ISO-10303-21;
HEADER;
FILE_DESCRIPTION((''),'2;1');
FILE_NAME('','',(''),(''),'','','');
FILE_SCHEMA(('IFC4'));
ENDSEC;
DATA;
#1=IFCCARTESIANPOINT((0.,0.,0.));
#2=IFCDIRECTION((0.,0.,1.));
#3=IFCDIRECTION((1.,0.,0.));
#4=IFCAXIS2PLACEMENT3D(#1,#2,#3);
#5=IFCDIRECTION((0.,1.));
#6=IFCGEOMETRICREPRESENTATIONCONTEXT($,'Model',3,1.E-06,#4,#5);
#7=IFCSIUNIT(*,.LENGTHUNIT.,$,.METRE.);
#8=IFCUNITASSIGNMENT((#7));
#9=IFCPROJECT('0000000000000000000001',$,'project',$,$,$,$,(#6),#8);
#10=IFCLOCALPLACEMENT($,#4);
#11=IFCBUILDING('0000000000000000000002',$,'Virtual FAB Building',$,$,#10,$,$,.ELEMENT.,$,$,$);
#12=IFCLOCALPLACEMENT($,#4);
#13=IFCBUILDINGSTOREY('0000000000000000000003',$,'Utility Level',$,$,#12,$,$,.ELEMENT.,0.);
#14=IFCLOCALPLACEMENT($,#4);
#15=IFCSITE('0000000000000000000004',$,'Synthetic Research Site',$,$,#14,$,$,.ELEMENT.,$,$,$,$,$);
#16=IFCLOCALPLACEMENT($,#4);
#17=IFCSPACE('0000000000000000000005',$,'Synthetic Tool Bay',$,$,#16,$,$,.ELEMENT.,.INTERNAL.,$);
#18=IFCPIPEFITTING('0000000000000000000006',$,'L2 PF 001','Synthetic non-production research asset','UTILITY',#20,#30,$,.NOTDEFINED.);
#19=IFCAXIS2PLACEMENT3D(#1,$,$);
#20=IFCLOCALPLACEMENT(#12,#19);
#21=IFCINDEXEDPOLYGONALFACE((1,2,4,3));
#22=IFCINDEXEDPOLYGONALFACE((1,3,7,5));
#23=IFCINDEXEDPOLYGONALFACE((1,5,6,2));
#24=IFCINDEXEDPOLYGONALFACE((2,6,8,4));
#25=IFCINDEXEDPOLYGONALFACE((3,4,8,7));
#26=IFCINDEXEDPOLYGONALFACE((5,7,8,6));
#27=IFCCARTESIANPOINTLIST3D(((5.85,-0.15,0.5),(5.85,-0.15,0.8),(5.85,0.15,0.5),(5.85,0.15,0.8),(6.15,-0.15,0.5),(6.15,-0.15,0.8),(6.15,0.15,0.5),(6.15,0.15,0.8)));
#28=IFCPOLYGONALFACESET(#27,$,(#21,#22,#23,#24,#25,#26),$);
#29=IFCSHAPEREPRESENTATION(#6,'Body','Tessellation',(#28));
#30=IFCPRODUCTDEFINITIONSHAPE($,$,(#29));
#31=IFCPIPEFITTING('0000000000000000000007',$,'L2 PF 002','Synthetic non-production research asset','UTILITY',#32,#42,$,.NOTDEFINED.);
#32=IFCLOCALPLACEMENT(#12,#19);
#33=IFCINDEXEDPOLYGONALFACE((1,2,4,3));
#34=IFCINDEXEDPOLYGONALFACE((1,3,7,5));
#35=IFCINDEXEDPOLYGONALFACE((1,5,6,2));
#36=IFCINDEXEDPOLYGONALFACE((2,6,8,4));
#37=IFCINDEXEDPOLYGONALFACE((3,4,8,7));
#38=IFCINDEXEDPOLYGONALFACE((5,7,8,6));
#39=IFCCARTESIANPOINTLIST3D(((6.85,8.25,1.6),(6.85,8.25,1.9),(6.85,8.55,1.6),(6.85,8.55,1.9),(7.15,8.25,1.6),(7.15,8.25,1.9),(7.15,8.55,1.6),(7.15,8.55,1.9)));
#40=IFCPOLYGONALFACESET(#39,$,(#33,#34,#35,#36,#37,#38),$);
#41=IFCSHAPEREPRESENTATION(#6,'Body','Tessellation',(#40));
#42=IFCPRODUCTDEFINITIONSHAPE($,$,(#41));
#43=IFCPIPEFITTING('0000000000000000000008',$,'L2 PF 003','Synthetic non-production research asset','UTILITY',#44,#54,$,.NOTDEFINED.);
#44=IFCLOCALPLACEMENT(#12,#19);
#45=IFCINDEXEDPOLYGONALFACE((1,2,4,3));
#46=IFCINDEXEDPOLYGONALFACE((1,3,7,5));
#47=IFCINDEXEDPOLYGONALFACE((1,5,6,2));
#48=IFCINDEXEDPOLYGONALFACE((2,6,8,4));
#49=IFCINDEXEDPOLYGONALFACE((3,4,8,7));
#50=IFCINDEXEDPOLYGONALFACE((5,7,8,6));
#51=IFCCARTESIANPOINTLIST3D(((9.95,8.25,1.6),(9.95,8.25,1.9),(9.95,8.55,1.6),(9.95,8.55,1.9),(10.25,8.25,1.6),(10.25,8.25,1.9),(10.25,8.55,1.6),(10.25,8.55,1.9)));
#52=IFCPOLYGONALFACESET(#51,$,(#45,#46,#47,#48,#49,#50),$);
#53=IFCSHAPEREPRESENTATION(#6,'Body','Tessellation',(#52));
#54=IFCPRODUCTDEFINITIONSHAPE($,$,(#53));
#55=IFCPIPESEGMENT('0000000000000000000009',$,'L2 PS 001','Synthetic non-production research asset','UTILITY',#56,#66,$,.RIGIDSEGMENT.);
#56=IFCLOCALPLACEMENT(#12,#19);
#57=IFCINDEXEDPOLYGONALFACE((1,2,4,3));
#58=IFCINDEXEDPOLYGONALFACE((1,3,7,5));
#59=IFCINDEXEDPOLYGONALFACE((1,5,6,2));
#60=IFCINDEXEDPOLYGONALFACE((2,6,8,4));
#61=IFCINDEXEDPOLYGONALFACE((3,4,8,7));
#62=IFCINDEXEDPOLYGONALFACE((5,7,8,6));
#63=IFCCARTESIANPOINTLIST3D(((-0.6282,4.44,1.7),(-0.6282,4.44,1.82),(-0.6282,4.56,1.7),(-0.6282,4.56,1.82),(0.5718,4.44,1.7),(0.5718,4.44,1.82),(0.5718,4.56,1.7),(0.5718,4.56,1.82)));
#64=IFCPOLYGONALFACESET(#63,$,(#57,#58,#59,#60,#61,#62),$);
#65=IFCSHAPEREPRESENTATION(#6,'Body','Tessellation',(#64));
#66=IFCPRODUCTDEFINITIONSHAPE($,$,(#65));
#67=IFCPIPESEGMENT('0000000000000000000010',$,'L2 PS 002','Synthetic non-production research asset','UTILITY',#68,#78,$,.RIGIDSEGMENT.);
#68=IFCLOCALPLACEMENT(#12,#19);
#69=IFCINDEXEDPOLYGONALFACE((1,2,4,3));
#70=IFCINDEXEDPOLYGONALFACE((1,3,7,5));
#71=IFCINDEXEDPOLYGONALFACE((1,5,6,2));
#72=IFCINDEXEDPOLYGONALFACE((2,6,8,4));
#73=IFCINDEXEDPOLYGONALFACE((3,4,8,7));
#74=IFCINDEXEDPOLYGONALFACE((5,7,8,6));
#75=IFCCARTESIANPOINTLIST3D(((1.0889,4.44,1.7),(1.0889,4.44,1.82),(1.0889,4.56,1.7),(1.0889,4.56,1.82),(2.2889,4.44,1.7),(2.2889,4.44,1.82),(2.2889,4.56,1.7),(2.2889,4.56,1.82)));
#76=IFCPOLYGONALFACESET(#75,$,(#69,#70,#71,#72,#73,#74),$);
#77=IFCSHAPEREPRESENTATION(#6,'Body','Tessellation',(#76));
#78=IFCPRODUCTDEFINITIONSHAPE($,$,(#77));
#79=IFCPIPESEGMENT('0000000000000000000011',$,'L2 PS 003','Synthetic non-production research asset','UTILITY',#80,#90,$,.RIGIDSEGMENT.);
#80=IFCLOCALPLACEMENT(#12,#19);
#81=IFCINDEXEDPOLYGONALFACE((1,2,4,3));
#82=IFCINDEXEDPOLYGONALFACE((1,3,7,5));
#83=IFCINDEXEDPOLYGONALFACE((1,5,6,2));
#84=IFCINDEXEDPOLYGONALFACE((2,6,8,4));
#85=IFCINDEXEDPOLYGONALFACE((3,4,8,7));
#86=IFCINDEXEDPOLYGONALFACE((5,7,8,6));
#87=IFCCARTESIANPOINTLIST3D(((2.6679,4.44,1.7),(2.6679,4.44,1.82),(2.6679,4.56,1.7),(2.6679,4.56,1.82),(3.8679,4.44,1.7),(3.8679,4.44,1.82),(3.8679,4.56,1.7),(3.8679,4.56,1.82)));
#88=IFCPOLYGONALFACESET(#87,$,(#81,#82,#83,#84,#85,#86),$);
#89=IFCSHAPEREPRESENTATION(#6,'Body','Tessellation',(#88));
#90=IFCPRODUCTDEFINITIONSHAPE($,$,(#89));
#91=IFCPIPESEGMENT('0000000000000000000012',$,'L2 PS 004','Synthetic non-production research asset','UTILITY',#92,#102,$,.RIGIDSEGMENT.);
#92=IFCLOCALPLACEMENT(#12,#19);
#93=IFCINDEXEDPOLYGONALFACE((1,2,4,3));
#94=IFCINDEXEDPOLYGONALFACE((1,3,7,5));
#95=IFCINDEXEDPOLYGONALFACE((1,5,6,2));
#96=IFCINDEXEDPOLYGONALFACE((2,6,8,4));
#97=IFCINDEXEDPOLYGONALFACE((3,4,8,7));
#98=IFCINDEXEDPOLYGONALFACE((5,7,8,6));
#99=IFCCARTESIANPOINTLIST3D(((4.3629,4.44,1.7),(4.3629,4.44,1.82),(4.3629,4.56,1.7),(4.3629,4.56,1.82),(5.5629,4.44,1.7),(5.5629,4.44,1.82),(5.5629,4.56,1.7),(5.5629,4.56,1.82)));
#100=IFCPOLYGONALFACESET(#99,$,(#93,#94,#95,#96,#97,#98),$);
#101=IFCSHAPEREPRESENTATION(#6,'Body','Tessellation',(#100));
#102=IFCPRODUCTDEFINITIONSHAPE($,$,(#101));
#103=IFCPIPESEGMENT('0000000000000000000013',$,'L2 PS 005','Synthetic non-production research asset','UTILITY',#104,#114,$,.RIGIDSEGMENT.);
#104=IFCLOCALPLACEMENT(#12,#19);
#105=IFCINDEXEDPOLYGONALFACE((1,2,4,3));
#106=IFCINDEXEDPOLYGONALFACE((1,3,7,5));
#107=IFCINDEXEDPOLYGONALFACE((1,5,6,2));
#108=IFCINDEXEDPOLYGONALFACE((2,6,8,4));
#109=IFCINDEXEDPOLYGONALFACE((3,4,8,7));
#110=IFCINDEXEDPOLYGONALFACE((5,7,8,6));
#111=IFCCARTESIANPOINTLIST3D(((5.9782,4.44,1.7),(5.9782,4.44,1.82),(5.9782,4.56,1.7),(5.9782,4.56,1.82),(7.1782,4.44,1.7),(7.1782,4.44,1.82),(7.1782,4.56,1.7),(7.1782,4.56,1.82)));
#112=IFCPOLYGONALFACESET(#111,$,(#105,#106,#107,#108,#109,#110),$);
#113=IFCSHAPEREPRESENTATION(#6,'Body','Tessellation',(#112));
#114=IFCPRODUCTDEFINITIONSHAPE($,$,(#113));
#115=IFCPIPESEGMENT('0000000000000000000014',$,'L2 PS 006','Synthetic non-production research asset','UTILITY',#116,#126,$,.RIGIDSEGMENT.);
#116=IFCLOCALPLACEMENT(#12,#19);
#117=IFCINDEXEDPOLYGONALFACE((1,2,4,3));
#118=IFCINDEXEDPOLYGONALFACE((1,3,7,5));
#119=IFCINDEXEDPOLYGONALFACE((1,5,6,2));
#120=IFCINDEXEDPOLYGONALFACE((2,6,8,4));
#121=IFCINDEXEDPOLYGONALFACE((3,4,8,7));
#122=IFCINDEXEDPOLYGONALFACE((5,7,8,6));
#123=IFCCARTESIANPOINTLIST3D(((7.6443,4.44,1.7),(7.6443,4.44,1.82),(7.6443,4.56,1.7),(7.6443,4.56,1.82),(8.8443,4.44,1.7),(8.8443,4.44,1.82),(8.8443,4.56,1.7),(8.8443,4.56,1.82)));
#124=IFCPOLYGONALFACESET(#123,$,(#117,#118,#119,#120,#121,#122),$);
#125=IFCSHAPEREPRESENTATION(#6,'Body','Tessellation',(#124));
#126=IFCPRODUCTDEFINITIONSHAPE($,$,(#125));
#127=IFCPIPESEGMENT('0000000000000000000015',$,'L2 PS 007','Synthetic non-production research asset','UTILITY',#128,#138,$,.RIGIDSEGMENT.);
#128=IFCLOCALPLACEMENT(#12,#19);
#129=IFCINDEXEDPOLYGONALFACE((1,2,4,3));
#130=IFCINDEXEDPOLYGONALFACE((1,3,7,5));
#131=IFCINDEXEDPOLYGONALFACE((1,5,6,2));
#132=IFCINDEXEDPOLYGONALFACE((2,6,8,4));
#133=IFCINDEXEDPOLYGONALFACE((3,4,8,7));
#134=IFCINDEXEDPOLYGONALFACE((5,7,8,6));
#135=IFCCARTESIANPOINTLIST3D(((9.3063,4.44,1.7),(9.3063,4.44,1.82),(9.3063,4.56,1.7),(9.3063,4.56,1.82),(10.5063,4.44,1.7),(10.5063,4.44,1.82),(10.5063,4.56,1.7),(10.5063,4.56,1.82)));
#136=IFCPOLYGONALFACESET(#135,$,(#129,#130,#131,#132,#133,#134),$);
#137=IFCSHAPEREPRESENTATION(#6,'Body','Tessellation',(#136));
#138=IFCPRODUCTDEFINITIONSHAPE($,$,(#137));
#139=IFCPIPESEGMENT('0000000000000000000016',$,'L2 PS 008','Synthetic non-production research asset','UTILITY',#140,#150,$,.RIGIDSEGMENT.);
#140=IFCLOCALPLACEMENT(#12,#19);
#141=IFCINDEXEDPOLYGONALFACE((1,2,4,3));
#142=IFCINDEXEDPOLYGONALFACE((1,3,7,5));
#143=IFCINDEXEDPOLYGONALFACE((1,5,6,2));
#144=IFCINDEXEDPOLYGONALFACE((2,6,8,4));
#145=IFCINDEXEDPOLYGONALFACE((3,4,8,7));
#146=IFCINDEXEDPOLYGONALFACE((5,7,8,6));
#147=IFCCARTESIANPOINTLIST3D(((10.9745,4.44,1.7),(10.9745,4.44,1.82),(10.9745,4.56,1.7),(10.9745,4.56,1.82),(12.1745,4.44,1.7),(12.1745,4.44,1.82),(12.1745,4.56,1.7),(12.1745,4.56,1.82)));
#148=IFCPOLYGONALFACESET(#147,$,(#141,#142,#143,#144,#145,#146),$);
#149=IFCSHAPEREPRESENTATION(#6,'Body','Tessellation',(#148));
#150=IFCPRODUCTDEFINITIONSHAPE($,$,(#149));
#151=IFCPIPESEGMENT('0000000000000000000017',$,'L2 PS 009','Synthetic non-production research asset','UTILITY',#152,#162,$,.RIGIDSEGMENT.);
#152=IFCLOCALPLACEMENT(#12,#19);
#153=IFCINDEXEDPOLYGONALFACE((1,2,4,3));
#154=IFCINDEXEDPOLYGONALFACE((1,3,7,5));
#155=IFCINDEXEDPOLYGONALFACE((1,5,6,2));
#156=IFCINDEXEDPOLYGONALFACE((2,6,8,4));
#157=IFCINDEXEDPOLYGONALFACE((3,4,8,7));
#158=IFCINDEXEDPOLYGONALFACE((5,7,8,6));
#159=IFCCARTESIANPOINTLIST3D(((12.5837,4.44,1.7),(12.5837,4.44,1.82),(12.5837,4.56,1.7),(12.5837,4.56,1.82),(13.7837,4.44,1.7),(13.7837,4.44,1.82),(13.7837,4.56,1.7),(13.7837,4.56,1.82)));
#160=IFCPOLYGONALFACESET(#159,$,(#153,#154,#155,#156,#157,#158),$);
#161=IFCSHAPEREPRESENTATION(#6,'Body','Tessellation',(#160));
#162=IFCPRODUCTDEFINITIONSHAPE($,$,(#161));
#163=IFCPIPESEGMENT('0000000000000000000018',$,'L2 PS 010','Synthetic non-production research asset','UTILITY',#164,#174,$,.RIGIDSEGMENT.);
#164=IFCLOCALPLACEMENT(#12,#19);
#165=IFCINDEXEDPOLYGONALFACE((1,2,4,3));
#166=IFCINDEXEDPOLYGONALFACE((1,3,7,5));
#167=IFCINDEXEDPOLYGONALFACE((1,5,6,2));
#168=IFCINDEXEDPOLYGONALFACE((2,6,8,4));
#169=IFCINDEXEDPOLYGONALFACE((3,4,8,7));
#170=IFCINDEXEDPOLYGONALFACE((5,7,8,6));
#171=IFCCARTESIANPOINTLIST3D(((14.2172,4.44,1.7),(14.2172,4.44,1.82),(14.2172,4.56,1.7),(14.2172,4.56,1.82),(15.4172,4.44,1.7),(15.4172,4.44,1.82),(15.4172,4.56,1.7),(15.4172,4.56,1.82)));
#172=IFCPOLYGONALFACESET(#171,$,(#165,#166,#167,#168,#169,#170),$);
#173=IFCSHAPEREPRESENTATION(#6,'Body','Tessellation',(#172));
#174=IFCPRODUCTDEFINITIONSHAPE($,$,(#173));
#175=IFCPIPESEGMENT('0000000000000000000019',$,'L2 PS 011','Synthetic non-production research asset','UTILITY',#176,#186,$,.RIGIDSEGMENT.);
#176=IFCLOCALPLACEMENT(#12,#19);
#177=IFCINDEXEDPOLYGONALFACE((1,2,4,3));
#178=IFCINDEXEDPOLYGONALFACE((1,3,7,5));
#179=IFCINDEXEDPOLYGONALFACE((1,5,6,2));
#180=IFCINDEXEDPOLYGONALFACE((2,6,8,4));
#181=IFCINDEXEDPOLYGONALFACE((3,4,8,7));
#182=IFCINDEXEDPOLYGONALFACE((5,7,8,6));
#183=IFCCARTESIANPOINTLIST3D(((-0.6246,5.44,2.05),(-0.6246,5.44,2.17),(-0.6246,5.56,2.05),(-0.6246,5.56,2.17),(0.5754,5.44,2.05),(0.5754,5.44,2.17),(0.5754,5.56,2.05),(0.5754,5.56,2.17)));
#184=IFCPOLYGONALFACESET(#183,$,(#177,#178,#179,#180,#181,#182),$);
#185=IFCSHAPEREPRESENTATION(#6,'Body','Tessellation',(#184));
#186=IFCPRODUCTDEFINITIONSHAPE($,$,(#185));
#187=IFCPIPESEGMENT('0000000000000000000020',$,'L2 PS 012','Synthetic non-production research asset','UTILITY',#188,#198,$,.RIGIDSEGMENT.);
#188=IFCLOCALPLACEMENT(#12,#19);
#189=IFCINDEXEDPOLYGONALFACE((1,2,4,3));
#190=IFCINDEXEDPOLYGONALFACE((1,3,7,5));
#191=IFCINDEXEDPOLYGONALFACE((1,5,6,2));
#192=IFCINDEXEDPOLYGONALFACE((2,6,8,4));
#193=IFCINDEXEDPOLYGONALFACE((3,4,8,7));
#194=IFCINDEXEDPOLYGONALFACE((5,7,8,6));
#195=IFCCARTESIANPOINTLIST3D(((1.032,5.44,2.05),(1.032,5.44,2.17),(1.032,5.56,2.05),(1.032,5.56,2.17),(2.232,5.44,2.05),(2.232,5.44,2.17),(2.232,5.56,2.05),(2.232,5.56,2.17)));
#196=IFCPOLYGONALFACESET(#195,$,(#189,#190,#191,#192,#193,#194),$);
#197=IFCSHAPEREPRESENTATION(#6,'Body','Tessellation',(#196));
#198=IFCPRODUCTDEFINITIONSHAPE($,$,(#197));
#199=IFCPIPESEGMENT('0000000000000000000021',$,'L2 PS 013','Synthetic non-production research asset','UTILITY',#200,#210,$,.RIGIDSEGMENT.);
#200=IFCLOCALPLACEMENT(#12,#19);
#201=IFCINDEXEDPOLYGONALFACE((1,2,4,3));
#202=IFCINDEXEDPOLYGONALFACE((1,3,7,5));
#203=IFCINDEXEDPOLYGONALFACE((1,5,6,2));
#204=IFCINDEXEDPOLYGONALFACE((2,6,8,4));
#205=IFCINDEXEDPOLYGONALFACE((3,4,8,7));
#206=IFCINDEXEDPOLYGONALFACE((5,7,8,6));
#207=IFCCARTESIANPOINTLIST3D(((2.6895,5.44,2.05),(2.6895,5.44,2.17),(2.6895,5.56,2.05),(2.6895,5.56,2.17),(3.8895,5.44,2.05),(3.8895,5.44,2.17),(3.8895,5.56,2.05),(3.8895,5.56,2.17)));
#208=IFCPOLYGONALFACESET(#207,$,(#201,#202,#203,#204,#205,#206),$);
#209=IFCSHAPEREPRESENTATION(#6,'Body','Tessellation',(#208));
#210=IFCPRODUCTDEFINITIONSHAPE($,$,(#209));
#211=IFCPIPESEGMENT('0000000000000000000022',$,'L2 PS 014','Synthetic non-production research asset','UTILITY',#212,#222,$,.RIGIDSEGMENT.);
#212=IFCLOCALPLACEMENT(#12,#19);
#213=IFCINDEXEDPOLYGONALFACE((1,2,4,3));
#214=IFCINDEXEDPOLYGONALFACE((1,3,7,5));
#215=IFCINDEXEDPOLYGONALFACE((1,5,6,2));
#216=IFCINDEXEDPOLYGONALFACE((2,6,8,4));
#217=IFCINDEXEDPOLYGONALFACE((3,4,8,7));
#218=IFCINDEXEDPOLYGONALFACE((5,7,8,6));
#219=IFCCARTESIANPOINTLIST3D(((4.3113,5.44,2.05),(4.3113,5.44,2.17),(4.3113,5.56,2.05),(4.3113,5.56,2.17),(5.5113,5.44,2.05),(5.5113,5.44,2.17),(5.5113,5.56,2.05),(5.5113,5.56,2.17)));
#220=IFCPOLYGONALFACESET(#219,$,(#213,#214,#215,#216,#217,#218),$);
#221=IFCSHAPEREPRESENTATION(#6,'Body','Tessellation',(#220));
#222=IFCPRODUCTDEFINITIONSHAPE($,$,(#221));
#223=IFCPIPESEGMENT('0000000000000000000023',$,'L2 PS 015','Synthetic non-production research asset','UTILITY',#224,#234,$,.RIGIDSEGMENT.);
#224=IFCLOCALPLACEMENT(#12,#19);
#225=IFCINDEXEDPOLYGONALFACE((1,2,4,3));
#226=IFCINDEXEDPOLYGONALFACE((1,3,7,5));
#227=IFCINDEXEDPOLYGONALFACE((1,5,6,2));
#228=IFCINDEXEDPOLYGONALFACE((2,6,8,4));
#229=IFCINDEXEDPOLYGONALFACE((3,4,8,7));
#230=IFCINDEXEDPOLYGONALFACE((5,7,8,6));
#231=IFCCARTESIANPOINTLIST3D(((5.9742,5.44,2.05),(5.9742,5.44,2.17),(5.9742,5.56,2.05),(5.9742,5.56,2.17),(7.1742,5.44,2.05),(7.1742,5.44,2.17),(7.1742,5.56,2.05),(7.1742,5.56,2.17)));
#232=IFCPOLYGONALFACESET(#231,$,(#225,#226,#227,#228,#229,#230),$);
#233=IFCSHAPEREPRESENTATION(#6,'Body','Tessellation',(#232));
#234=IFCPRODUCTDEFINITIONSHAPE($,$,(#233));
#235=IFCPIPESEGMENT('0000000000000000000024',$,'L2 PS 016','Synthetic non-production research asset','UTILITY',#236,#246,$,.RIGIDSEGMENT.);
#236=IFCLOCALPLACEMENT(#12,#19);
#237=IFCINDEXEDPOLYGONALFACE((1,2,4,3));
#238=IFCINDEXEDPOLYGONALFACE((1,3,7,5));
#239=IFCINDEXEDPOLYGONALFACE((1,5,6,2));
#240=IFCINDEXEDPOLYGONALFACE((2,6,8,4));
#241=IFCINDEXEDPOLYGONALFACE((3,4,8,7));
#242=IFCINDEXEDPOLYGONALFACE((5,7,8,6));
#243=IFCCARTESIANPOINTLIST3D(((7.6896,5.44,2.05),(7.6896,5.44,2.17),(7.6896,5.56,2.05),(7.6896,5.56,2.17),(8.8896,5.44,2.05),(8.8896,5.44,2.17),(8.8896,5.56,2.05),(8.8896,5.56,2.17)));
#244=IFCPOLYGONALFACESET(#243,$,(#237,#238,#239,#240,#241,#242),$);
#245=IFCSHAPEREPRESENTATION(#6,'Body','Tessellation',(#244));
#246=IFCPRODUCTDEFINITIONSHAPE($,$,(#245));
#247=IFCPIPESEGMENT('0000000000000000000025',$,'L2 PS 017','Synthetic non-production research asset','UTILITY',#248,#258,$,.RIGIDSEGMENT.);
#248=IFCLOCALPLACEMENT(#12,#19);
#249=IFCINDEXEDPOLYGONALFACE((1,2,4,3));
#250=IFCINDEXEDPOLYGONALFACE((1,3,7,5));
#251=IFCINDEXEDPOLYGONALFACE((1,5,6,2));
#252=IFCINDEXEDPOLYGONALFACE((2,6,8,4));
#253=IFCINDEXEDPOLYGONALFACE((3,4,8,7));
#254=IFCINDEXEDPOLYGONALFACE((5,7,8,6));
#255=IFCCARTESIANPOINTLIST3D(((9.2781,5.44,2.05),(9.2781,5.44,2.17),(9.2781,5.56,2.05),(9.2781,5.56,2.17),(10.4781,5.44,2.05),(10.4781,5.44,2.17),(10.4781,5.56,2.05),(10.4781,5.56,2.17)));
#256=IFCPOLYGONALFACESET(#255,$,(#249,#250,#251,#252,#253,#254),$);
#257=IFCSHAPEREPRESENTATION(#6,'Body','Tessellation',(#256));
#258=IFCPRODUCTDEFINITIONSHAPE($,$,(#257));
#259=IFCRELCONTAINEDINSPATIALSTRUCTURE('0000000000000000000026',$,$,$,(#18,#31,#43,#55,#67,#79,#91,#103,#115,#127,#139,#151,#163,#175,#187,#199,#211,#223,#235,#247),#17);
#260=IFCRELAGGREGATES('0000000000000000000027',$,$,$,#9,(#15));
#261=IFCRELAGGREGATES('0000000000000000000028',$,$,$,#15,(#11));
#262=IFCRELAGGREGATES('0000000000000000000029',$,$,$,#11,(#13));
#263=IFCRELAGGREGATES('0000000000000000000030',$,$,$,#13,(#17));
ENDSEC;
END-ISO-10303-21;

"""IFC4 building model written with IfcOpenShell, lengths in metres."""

from ifc_helpers import new_model, si_unit, direction, frame, origin_with_axes, origin_2d_with_axis, place, context, project, spatial, rectangle, extrude, element, save


model = new_model("IFC4")

# Units and contexts
model_context = context("Model", 3, precision=1e-06, world=origin_with_axes(), true_north=direction((0.0, 1.0)))
ifc_project = project(units=[si_unit("LENGTHUNIT", "METRE")], contexts=[model_context])

# Site, building, storey, space
site_placement = place(None, origin_with_axes())
site = spatial("IfcSite", under=ifc_project, at=site_placement, Name="Synthetic Research Site", CompositionType="ELEMENT")
building_placement = place(None, origin_with_axes())
building = spatial("IfcBuilding", under=site, at=building_placement, Name="Virtual FAB Building", CompositionType="ELEMENT")
storey_placement = place(None, origin_with_axes())
storey = spatial("IfcBuildingStorey", under=building, at=storey_placement, Name="Utility Level", CompositionType="ELEMENT", Elevation=0.0)
space_placement = place(None, origin_with_axes())
space = spatial("IfcSpace", under=storey, at=space_placement, Name="Synthetic Tool Bay", CompositionType="ELEMENT", PredefinedType="INTERNAL")

# Pipe fittings
for number, where, z_axis, x_axis, name in (
    (1, (6.0, 0.0, 0.5), (0.0, 0.0, 1.0), (1.0, 0.0, 0.0), "L2 PF 001"),
    (2, (7.0, 8.4, 1.6), (0.0, 0.0, 1.0), (1.0, 0.0, 0.0), "L2 PF 002"),
    (3, (10.1, 8.4, 1.6), (0.0, 0.0, 1.0), (1.0, 0.0, 0.0), "L2 PF 003"),
):
    element("IfcPipeFitting", number, at=place(None, frame(where, z_axis=z_axis, x_axis=x_axis)), inside=space, Name=name, Description="Synthetic non-production research asset", ObjectType="UTILITY", PredefinedType="NOTDEFINED", context=model_context, shape_type="SweptSolid", body=[
        extrude(rectangle(XDim=0.3, YDim=0.3, at=origin_2d_with_axis()), origin_with_axes(), (0.0, 0.0, 1.0), 0.3),
    ])

# Pipe segments
for number, where, z_axis, x_axis, name in (
    (4, (-0.0282, 4.5, 1.7), (0.0, 0.0, 1.0), (1.0, 0.0, 0.0), "L2 PS 001"),
    (5, (1.6889, 4.5, 1.7), (0.0, 0.0, 1.0), (1.0, 0.0, 0.0), "L2 PS 002"),
    (6, (3.2679, 4.5, 1.7), (0.0, 0.0, 1.0), (1.0, 0.0, 0.0), "L2 PS 003"),
    (7, (4.9629, 4.5, 1.7), (0.0, 0.0, 1.0), (1.0, 0.0, 0.0), "L2 PS 004"),
    (8, (6.5782, 4.5, 1.7), (0.0, 0.0, 1.0), (1.0, 0.0, 0.0), "L2 PS 005"),
    (9, (8.2443, 4.5, 1.7), (0.0, 0.0, 1.0), (1.0, 0.0, 0.0), "L2 PS 006"),
    (10, (9.9063, 4.5, 1.7), (0.0, 0.0, 1.0), (1.0, 0.0, 0.0), "L2 PS 007"),
    (11, (11.5745, 4.5, 1.7), (0.0, 0.0, 1.0), (1.0, 0.0, 0.0), "L2 PS 008"),
    (12, (13.1837, 4.5, 1.7), (0.0, 0.0, 1.0), (1.0, 0.0, 0.0), "L2 PS 009"),
    (13, (14.8172, 4.5, 1.7), (0.0, 0.0, 1.0), (1.0, 0.0, 0.0), "L2 PS 010"),
    (14, (-0.0246, 5.5, 2.05), (0.0, 0.0, 1.0), (1.0, 0.0, 0.0), "L2 PS 011"),
    (15, (1.632, 5.5, 2.05), (0.0, 0.0, 1.0), (1.0, 0.0, 0.0), "L2 PS 012"),
    (16, (3.2895, 5.5, 2.05), (0.0, 0.0, 1.0), (1.0, 0.0, 0.0), "L2 PS 013"),
    (17, (4.9113, 5.5, 2.05), (0.0, 0.0, 1.0), (1.0, 0.0, 0.0), "L2 PS 014"),
    (18, (6.5742, 5.5, 2.05), (0.0, 0.0, 1.0), (1.0, 0.0, 0.0), "L2 PS 015"),
    (19, (8.2896, 5.5, 2.05), (0.0, 0.0, 1.0), (1.0, 0.0, 0.0), "L2 PS 016"),
    (20, (9.8781, 5.5, 2.05), (0.0, 0.0, 1.0), (1.0, 0.0, 0.0), "L2 PS 017"),
):
    element("IfcPipeSegment", number, at=place(None, frame(where, z_axis=z_axis, x_axis=x_axis)), inside=space, Name=name, Description="Synthetic non-production research asset", ObjectType="UTILITY", PredefinedType="RIGIDSEGMENT", context=model_context, shape_type="SweptSolid", body=[
        extrude(rectangle(XDim=1.2, YDim=0.12, at=origin_2d_with_axis()), origin_with_axes(), (0.0, 0.0, 1.0), 0.12),
    ])

save(model, "model.ifc")
